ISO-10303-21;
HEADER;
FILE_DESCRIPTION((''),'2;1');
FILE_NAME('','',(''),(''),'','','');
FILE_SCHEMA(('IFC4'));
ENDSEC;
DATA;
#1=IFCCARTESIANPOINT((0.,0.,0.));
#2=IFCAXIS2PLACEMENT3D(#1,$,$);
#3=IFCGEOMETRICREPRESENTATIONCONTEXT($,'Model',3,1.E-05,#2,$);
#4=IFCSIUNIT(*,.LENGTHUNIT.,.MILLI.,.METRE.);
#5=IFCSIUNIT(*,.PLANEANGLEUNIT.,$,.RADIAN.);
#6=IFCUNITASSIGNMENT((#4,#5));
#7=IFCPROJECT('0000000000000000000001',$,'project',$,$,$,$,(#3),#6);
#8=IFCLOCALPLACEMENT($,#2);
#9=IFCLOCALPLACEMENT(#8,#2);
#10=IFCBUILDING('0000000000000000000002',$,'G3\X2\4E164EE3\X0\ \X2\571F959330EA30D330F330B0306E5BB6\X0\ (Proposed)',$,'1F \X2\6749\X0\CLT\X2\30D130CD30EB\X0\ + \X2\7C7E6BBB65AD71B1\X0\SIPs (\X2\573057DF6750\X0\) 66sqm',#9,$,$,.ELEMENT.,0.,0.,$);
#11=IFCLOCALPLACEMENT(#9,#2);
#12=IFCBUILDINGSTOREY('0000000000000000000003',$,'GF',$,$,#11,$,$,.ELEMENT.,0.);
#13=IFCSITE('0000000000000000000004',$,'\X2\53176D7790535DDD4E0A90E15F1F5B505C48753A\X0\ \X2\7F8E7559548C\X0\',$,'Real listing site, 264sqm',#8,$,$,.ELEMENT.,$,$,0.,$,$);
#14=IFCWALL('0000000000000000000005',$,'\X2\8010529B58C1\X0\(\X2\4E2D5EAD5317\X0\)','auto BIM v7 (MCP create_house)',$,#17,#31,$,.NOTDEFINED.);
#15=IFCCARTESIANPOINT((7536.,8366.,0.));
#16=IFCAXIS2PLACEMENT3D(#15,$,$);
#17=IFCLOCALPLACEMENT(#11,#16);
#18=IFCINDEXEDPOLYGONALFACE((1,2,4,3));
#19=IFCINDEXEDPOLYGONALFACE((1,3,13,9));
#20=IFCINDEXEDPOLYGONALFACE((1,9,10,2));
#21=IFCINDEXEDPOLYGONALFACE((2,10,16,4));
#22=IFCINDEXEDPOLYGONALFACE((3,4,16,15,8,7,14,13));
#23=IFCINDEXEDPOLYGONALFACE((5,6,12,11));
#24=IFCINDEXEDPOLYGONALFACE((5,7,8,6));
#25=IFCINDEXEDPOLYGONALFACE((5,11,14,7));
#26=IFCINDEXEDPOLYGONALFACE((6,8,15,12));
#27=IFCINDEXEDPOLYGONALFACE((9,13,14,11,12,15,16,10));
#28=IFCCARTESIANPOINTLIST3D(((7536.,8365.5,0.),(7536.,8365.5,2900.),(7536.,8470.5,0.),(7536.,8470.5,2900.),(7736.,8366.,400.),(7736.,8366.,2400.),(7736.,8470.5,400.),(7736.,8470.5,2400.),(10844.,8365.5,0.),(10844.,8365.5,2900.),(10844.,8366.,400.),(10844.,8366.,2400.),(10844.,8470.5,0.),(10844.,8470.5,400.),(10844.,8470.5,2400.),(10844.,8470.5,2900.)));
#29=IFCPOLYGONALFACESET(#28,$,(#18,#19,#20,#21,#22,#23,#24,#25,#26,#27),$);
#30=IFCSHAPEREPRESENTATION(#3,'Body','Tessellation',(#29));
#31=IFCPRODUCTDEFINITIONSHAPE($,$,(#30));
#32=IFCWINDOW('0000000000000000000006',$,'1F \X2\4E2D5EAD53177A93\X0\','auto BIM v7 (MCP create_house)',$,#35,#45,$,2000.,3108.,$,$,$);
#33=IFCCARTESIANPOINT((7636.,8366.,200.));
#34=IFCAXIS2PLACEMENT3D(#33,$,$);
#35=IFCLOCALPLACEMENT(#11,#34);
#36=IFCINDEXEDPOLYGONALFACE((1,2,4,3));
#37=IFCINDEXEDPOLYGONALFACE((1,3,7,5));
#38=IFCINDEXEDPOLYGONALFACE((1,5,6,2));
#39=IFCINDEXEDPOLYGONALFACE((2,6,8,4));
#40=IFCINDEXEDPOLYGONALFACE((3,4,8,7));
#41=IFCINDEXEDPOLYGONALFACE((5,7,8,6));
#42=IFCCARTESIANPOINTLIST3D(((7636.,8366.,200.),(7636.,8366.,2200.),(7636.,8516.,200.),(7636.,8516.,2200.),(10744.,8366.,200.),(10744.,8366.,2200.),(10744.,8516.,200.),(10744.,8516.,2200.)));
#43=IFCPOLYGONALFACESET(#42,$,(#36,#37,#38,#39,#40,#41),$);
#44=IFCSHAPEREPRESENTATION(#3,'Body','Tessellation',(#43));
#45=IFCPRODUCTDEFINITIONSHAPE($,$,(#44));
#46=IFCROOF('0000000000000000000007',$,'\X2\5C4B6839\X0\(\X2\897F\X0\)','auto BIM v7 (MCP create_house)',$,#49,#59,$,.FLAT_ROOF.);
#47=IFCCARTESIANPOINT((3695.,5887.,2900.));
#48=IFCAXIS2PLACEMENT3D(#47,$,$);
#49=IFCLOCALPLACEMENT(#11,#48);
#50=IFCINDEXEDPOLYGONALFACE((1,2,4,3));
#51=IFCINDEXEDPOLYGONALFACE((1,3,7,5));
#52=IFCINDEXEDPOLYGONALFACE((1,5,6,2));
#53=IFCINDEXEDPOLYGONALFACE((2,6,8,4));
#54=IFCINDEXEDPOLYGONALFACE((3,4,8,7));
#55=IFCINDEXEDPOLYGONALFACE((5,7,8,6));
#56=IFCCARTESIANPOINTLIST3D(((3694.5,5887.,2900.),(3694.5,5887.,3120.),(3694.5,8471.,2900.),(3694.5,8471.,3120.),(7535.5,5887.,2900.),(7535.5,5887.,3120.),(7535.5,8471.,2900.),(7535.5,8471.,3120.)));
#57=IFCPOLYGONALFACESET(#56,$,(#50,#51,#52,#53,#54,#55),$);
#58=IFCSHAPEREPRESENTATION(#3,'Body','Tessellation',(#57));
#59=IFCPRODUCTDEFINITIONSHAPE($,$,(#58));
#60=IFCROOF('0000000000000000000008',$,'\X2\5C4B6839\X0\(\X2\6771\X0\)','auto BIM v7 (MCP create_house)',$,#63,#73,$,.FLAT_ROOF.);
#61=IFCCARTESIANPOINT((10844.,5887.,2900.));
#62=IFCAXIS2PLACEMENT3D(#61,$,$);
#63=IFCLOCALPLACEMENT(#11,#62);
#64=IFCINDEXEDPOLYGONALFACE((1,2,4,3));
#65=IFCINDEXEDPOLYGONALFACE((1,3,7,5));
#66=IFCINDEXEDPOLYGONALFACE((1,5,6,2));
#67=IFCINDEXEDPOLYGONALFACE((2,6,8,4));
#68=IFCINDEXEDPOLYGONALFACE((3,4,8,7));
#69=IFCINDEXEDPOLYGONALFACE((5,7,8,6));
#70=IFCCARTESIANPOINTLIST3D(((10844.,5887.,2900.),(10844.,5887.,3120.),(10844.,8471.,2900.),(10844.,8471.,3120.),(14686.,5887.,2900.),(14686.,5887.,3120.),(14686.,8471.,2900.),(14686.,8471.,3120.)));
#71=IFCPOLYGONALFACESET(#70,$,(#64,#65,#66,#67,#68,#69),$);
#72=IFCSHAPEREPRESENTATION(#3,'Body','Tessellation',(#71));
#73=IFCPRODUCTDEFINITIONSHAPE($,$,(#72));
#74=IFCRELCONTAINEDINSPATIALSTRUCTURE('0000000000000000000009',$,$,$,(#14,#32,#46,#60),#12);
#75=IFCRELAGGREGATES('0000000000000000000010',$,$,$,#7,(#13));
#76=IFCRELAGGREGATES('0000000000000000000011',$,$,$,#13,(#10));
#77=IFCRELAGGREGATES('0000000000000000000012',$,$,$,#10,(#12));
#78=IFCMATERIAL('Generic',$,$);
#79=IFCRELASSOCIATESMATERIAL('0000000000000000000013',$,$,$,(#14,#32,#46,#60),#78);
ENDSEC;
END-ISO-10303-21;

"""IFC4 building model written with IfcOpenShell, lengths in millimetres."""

from ifc_helpers import new_model, si_unit, frame, frame_2d, origin, place, context, project, spatial, rectangle, extrude, material, element, fill, save


model = new_model("IFC4")

# Units and contexts
model_context = context("Model", 3, precision=1e-05, world=origin())
ifc_project = project(units=[si_unit("LENGTHUNIT", "METRE", prefix="MILLI"), si_unit("PLANEANGLEUNIT", "RADIAN")], contexts=[model_context])

# Site, building, storey
site_placement = place(None, origin())
site = spatial("IfcSite", under=ifc_project, at=site_placement, Name="北海道川上郡弟子屈町 美留和", ObjectType="Real listing site, 264sqm", CompositionType="ELEMENT", RefElevation=0.0)
building_placement = place(site_placement, origin())
building = spatial("IfcBuilding", under=site, at=building_placement, Name="G3世代 土間リビングの家 (Proposed)", ObjectType="1F 杉CLTパネル + 籾殻断熱SIPs (地域材) 66sqm", CompositionType="ELEMENT", ElevationOfRefHeight=0.0, ElevationOfTerrain=0.0)
storey_placement = place(building_placement, origin())
storey = spatial("IfcBuildingStorey", under=building, at=storey_placement, Name="GF", CompositionType="ELEMENT", Elevation=0.0)

# Shared definitions
ifc_material = material(Name="Generic")

# Wall, opening, window
wall_1_placement = place(storey_placement, frame((7536.0, 8366.0, 0.0)))
wall_1 = element("IfcWall", 1, at=wall_1_placement, inside=storey, material=ifc_material, Name="耐力壁(中庭北)", Description="auto BIM v7 (MCP create_house)", PredefinedType="NOTDEFINED", context=model_context, shape_type="SweptSolid", body=[
    extrude(rectangle(XDim=3308.0, YDim=105.0, at=frame_2d((1654.0, 52.0))), frame((7536.0, 8366.0, 0.0)), (0.0, 0.0, 1.0), 2900.0),
])
opening_1_placement = place(storey_placement, frame((7636.0, 8366.0, 200.0)))
opening_1 = element("IfcOpeningElement", 2, at=opening_1_placement, cuts=wall_1, PredefinedType="NOTDEFINED", context=model_context, shape_type="SweptSolid", body=[
    extrude(rectangle(XDim=3108.0, YDim=150.0, at=frame_2d((1554.0, 75.0))), frame((7636.0, 8366.0, 200.0)), (0.0, 0.0, 1.0), 2000.0),
])
window_1_placement = place(storey_placement, frame((7636.0, 8366.0, 200.0)))
window_1 = element("IfcWindow", 3, at=window_1_placement, inside=storey, material=ifc_material, Name="1F 中庭北窓", Description="auto BIM v7 (MCP create_house)", OverallHeight=2000.0, OverallWidth=3108.0, context=model_context, shape_type="SweptSolid", body=[
    extrude(rectangle(XDim=3108.0, YDim=150.0, at=frame_2d((1554.0, 75.0))), frame((7636.0, 8366.0, 200.0)), (0.0, 0.0, 1.0), 2000.0),
])
fill(opening_1, window_1)

# Roofs
roof_1_placement = place(storey_placement, frame((3695.0, 5887.0, 2900.0)))
element("IfcRoof", 4, at=roof_1_placement, inside=storey, material=ifc_material, Name="屋根(西)", Description="auto BIM v7 (MCP create_house)", PredefinedType="FLAT_ROOF", context=model_context, shape_type="SweptSolid", body=[
    extrude(rectangle(XDim=3841.0, YDim=2584.0, at=frame_2d((1920.0, 1292.0))), frame((3695.0, 5887.0, 2900.0)), (0.0, 0.0, 1.0), 220.0),
])
roof_2_placement = place(storey_placement, frame((10844.0, 5887.0, 2900.0)))
element("IfcRoof", 5, at=roof_2_placement, inside=storey, material=ifc_material, Name="屋根(東)", Description="auto BIM v7 (MCP create_house)", PredefinedType="FLAT_ROOF", context=model_context, shape_type="SweptSolid", body=[
    extrude(rectangle(XDim=3842.0, YDim=2584.0, at=frame_2d((1921.0, 1292.0))), frame((10844.0, 5887.0, 2900.0)), (0.0, 0.0, 1.0), 220.0),
])

save(model, "model.ifc")
